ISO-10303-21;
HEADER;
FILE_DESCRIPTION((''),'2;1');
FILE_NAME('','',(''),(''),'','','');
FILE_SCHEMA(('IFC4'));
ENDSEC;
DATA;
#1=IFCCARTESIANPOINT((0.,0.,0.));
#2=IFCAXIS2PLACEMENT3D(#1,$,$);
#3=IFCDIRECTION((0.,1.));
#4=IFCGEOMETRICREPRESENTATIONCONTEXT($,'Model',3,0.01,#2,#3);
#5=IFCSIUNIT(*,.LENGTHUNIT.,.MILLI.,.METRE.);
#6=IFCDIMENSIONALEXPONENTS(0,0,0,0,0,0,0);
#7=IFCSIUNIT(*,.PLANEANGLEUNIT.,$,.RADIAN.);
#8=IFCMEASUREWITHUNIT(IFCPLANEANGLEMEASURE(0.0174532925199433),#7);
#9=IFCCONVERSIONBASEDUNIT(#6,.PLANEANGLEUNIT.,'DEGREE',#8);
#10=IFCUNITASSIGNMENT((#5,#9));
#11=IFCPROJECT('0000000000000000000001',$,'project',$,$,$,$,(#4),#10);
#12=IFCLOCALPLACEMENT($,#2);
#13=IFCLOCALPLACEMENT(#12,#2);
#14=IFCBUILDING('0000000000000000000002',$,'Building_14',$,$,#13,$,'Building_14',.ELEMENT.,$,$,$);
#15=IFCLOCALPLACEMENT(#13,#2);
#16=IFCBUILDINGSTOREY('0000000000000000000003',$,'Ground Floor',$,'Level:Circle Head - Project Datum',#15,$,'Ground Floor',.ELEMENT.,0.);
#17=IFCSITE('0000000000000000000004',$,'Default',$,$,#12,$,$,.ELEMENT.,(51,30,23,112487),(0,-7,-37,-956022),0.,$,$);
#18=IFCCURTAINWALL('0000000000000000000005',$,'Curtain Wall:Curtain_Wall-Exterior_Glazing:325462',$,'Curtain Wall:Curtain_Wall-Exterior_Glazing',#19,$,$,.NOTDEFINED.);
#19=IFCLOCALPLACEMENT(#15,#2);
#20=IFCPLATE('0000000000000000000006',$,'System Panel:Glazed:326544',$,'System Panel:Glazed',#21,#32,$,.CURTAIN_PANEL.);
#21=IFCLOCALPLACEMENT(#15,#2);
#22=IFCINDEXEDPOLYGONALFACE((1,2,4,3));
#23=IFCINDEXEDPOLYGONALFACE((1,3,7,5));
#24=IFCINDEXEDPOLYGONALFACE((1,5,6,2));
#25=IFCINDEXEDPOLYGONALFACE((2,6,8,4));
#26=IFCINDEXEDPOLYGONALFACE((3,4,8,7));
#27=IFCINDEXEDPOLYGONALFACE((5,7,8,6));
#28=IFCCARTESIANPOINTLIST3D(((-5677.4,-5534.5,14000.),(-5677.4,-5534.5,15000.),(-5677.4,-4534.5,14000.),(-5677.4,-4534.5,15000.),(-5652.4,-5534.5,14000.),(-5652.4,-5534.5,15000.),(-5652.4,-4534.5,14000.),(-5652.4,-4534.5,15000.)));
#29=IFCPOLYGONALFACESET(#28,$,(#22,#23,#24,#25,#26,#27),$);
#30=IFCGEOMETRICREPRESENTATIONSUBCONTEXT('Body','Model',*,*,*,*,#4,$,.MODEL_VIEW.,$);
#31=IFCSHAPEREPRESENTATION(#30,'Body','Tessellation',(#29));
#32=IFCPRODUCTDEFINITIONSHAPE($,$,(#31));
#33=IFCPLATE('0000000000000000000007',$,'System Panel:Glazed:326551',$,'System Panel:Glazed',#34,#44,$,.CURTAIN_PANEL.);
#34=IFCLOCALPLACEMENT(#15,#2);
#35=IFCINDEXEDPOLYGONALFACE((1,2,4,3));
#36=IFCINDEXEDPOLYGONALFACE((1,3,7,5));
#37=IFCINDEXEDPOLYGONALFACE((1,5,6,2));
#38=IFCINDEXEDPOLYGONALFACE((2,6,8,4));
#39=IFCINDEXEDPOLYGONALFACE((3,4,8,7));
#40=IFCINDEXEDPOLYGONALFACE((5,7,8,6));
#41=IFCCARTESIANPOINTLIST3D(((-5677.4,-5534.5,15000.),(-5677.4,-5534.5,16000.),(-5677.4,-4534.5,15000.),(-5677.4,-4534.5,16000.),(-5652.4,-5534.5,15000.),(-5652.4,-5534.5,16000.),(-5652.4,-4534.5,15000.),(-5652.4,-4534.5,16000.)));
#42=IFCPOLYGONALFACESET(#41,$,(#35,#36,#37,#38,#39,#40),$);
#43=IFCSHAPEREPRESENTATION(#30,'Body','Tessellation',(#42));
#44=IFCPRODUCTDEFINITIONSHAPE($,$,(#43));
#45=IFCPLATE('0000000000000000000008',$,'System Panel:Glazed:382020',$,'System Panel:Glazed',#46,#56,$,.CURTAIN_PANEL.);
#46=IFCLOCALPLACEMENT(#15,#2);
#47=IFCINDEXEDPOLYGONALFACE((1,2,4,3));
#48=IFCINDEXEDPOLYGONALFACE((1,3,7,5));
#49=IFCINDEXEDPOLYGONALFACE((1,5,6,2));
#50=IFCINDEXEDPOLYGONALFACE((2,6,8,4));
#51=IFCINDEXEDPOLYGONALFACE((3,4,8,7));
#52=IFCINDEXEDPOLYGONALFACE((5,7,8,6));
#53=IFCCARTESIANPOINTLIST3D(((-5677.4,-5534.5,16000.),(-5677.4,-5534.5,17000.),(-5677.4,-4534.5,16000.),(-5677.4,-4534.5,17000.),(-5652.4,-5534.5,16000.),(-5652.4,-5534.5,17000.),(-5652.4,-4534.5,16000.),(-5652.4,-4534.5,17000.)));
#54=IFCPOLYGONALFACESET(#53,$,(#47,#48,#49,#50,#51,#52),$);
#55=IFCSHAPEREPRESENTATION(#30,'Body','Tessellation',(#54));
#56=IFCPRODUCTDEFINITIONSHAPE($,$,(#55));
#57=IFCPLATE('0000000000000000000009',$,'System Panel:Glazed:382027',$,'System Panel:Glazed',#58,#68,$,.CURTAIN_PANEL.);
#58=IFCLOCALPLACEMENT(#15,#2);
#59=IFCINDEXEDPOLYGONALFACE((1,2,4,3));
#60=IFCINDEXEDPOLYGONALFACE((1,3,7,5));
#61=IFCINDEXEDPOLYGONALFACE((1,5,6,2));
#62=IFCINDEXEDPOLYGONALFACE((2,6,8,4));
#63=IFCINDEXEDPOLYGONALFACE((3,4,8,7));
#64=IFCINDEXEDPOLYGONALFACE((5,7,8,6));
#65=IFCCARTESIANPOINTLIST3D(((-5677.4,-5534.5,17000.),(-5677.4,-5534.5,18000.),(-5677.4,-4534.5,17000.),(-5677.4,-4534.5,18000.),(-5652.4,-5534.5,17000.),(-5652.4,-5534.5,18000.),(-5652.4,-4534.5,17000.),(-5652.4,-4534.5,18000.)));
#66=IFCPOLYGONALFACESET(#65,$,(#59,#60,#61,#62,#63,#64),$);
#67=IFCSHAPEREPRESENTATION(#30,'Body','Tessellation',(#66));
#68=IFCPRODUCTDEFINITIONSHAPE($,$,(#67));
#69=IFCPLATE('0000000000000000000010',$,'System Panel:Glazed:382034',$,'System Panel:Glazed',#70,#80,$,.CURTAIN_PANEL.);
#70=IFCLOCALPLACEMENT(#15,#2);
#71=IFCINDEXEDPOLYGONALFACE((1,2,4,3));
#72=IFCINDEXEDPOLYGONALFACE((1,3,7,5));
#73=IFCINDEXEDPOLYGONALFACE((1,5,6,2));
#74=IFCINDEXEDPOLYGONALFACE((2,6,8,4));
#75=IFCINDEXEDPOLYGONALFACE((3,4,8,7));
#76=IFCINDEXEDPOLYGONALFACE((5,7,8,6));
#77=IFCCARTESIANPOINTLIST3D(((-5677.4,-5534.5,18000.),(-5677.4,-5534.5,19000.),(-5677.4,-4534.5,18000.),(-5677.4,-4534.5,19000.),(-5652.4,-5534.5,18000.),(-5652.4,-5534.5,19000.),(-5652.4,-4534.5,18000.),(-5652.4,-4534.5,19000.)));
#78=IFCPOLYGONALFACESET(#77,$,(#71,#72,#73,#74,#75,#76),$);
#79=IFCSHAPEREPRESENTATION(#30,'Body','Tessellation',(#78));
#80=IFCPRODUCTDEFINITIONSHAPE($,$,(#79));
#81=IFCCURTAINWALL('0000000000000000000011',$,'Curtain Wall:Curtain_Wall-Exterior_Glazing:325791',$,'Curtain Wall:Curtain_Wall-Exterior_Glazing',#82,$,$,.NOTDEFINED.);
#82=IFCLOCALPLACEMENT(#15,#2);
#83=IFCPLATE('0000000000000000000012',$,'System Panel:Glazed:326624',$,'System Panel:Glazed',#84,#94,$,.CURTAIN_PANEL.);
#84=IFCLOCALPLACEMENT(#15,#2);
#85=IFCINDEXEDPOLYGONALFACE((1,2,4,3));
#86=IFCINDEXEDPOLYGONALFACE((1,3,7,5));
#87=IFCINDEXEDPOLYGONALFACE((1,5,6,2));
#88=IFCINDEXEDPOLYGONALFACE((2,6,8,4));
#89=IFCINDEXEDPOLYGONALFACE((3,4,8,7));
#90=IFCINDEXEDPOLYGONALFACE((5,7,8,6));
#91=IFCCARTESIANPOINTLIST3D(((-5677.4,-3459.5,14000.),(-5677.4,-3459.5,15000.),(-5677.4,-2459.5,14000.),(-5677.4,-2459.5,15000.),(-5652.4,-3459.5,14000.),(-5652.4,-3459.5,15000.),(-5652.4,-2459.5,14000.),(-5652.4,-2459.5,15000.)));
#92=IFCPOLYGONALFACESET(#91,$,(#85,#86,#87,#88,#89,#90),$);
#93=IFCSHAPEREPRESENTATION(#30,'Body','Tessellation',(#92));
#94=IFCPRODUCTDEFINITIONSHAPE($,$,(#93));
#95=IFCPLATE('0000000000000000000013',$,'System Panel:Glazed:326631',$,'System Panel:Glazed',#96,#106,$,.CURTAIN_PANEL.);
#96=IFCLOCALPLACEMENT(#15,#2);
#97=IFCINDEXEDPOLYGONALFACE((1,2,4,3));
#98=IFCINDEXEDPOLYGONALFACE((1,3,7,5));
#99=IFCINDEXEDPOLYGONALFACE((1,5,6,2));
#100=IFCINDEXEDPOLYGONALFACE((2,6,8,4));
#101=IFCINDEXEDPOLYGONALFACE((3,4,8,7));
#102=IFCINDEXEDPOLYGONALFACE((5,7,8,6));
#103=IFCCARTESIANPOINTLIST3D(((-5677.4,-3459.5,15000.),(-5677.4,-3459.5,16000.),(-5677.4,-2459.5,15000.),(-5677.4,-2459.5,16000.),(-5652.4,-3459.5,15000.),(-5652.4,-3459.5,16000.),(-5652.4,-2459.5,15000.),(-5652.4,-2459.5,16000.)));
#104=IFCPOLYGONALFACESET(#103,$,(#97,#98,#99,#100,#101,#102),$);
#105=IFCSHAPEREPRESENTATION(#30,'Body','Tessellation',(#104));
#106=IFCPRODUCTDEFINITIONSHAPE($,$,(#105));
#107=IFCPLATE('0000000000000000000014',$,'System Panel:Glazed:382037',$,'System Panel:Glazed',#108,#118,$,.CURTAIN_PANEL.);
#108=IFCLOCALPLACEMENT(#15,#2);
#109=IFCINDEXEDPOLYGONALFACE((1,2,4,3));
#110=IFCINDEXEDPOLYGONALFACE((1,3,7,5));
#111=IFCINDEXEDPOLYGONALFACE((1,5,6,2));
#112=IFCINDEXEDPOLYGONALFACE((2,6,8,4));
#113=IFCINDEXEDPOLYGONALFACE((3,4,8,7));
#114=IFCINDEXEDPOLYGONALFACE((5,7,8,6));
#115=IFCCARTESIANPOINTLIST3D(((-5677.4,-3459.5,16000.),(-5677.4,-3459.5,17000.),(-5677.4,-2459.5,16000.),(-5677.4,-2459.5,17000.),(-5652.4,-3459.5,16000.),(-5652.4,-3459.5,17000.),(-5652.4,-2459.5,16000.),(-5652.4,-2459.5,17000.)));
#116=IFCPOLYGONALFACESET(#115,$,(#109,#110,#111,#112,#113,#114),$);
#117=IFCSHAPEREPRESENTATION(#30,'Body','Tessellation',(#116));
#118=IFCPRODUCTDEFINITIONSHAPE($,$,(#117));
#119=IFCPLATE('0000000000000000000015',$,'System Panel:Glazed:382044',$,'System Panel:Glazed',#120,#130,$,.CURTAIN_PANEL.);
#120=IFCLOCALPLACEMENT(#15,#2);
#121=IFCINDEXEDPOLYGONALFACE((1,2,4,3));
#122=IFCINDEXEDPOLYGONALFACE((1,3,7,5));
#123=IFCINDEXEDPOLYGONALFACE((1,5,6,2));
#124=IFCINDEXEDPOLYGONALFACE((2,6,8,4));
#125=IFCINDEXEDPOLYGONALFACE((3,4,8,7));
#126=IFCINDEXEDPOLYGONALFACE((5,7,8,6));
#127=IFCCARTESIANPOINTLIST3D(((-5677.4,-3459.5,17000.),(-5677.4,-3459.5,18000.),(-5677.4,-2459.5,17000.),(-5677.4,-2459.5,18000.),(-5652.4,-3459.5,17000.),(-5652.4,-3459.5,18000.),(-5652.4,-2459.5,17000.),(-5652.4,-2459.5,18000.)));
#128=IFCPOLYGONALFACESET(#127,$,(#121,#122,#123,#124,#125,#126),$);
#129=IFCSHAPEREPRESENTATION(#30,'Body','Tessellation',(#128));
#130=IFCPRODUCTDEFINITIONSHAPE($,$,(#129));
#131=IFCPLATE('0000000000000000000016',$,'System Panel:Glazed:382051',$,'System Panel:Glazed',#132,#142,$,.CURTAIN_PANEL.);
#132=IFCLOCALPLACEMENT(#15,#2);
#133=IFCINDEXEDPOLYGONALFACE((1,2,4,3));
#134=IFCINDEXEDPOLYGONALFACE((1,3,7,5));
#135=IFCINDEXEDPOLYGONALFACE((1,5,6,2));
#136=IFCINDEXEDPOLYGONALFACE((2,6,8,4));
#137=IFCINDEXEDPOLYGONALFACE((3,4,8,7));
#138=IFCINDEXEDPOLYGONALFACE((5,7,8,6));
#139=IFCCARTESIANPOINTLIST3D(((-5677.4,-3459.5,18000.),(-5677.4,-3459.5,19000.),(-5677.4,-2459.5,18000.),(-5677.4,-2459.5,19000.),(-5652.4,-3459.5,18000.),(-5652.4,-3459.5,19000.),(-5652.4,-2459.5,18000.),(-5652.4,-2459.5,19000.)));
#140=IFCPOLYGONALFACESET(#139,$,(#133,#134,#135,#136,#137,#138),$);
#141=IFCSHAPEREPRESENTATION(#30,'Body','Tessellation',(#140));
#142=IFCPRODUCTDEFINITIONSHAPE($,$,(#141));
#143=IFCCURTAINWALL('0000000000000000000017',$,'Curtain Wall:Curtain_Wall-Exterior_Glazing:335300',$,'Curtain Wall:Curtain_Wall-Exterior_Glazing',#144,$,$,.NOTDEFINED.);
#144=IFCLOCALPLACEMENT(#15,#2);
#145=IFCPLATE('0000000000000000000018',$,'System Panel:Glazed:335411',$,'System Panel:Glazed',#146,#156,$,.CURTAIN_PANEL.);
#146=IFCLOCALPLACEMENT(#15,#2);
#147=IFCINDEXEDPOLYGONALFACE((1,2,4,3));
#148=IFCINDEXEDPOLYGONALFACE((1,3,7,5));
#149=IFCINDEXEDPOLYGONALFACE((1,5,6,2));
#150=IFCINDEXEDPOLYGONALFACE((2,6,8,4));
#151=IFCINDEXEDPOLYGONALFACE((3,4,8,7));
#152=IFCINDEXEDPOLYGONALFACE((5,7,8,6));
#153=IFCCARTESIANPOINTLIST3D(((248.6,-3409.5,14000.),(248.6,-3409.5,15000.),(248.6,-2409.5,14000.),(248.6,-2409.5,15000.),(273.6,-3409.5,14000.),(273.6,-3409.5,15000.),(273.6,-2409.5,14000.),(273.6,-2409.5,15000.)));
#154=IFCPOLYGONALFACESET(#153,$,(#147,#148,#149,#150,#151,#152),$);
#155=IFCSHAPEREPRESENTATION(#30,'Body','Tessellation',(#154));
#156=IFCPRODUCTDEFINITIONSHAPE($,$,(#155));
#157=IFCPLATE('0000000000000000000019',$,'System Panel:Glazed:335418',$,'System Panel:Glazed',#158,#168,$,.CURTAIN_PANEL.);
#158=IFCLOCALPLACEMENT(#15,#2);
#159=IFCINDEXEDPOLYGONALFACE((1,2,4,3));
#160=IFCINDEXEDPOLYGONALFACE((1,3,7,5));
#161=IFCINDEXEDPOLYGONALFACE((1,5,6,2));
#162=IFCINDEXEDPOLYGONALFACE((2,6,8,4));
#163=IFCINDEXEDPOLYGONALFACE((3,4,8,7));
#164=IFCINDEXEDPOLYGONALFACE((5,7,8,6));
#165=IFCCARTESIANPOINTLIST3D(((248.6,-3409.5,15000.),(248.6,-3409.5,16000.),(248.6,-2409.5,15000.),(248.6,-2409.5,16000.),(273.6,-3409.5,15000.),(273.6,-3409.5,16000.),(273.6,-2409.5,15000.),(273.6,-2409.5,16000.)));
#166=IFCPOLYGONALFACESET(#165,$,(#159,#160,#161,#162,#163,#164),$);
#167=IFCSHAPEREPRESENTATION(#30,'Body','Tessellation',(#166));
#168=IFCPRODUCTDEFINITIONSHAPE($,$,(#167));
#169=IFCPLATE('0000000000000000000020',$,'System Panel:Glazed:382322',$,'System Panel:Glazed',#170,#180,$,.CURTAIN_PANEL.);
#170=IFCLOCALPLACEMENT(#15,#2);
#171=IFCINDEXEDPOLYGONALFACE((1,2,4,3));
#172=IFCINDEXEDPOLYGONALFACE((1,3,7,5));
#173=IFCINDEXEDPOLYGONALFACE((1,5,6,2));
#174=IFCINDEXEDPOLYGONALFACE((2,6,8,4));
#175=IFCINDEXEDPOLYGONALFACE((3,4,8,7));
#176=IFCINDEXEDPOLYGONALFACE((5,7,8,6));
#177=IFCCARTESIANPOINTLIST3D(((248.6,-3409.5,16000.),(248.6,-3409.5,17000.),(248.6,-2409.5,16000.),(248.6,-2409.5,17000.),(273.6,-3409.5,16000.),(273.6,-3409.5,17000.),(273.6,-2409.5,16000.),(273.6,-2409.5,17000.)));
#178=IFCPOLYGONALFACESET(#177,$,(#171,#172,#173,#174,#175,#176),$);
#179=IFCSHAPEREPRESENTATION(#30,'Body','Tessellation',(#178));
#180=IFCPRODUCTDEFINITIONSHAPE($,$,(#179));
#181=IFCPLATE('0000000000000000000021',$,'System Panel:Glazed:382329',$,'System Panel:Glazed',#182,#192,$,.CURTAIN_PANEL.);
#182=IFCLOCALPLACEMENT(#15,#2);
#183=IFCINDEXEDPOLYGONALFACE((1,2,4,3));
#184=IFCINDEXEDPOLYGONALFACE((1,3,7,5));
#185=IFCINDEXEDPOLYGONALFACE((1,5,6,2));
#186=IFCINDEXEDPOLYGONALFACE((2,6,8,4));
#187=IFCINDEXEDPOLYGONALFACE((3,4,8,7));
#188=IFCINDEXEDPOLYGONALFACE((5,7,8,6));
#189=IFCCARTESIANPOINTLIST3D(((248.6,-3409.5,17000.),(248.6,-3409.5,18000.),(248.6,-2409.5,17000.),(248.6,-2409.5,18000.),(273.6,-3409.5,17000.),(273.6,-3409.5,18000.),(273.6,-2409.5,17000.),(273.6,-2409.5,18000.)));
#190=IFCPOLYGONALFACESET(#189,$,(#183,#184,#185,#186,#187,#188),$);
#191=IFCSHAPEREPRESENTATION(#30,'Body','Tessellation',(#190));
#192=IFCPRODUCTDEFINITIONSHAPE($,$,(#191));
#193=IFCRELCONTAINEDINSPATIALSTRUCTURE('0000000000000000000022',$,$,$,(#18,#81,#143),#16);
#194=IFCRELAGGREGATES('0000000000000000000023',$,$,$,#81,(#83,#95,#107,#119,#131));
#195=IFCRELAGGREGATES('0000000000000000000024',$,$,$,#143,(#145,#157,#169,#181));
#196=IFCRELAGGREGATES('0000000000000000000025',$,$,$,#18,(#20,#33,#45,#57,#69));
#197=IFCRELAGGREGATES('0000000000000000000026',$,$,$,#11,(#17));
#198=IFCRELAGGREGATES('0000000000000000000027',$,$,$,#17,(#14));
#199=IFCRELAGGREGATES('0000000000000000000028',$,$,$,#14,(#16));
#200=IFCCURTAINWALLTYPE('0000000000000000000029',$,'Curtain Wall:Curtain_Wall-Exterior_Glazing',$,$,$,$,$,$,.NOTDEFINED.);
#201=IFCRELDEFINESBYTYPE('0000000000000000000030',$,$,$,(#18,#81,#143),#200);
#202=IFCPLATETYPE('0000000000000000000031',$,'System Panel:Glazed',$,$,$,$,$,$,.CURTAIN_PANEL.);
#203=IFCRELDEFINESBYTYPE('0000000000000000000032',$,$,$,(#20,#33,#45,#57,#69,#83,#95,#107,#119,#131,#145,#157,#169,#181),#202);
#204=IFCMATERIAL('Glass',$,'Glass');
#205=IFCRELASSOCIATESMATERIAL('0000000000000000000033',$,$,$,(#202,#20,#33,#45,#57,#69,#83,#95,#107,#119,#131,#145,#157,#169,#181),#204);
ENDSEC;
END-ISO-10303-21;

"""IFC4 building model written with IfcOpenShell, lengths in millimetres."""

from ifc_helpers import new_model, entity, si_unit, converted_unit, direction, frame, origin, place, context, subcontext, project, spatial, indexed_curve, outline, extrude, source, transform, mapped, material, type_object, type_shapes, element, aggregate, save


model = new_model("IFC4")

# Units and contexts
model_context = context("Model", 3, precision=0.01, world=origin(), true_north=direction((0.0, 1.0)))
body_context = subcontext(model_context, "Body", "Model", "MODEL_VIEW")
ifc_project = project(units=[si_unit("LENGTHUNIT", "METRE", prefix="MILLI"), converted_unit("PLANEANGLEUNIT", "DEGREE", entity("IfcPlaneAngleMeasure", 0.0174532925199433), si_unit("PLANEANGLEUNIT", "RADIAN"), dimensions=[0, 0, 0, 0, 0, 0, 0])], contexts=[model_context])

# Site, building, storey
site_placement = place(None, origin())
site = spatial("IfcSite", under=ifc_project, at=site_placement, Name="Default", CompositionType="ELEMENT", RefLatitude=(51, 30, 23, 112487), RefLongitude=(0, -7, -37, -956022), RefElevation=0.0)
building_placement = place(site_placement, origin())
building = spatial("IfcBuilding", under=site, at=building_placement, Name="Building_14", LongName="Building_14", CompositionType="ELEMENT")
storey_placement = place(building_placement, origin())
storey = spatial("IfcBuildingStorey", under=building, at=storey_placement, Name="Ground Floor", ObjectType="Level:Circle Head - Project Datum", LongName="Ground Floor", CompositionType="ELEMENT", Elevation=0.0)

# Curtain walls, plates
curtain_wall_type = type_object("IfcCurtainWallType", Name="Curtain Wall:Curtain_Wall-Exterior_Glazing", PredefinedType="NOTDEFINED")
curtain_wall_1_placement = place(storey_placement, origin())
curtain_wall_1 = element("IfcCurtainWall", 1, at=curtain_wall_1_placement, inside=storey, type_object=curtain_wall_type, Name="Curtain Wall:Curtain_Wall-Exterior_Glazing:325462", ObjectType="Curtain Wall:Curtain_Wall-Exterior_Glazing", PredefinedType="NOTDEFINED")
ifc_material = material(Name="Glass", Category="Glass")
plate_type_1 = type_object("IfcPlateType", Name="System Panel:Glazed", PredefinedType="CURTAIN_PANEL", material=ifc_material)
shared_shape_1 = source(origin(), body_context, "Body", "SweptSolid", [
    extrude(outline(indexed_curve([(-12.5, -500.0), (12.5, -500.0), (12.5, 500.0), (-12.5, 500.0), (-12.5, -500.0)], self_intersect=False)), frame((0.0, -37.0, 0.0), z_axis=(0.0, 0.0, 1.0), x_axis=(0.0, 1.0, 0.0)), (0.0, 0.0, 1.0), 1000.0),
])
type_shapes(plate_type_1, [shared_shape_1])
plate_1_placement = place(curtain_wall_1_placement, frame((-5701.9, -5034.5, 14000.0), z_axis=(0.0, 0.0, 1.0), x_axis=(0.0, 1.0, 0.0)))
plate_1 = element("IfcPlate", 2, at=plate_1_placement, type_object=plate_type_1, material=ifc_material, Name="System Panel:Glazed:326544", ObjectType="System Panel:Glazed", PredefinedType="CURTAIN_PANEL", context=body_context, shape_type="MappedRepresentation", body=[
    mapped(shared_shape_1, transform((0.0, 0.0, 0.0), scale=1.0)),
])
plate_2_placement = place(curtain_wall_1_placement, frame((-5701.9, -5034.5, 15000.0), z_axis=(0.0, 0.0, 1.0), x_axis=(0.0, 1.0, 0.0)))
plate_2 = element("IfcPlate", 3, at=plate_2_placement, type_object=plate_type_1, material=ifc_material, Name="System Panel:Glazed:326551", ObjectType="System Panel:Glazed", PredefinedType="CURTAIN_PANEL", context=body_context, shape_type="MappedRepresentation", body=[
    mapped(shared_shape_1, transform((0.0, 0.0, 0.0), scale=1.0)),
])
plate_3_placement = place(curtain_wall_1_placement, frame((-5701.9, -5034.5, 16000.0), z_axis=(0.0, 0.0, 1.0), x_axis=(0.0, 1.0, 0.0)))
plate_3 = element("IfcPlate", 4, at=plate_3_placement, type_object=plate_type_1, material=ifc_material, Name="System Panel:Glazed:382020", ObjectType="System Panel:Glazed", PredefinedType="CURTAIN_PANEL", context=body_context, shape_type="MappedRepresentation", body=[
    mapped(shared_shape_1, transform((0.0, 0.0, 0.0), scale=1.0)),
])
plate_4_placement = place(curtain_wall_1_placement, frame((-5701.9, -5034.5, 17000.0), z_axis=(0.0, 0.0, 1.0), x_axis=(0.0, 1.0, 0.0)))
plate_4 = element("IfcPlate", 5, at=plate_4_placement, type_object=plate_type_1, material=ifc_material, Name="System Panel:Glazed:382027", ObjectType="System Panel:Glazed", PredefinedType="CURTAIN_PANEL", context=body_context, shape_type="MappedRepresentation", body=[
    mapped(shared_shape_1, transform((0.0, 0.0, 0.0), scale=1.0)),
])
plate_5_placement = place(curtain_wall_1_placement, frame((-5701.9, -5034.5, 18000.0), z_axis=(0.0, 0.0, 1.0), x_axis=(0.0, 1.0, 0.0)))
plate_5 = element("IfcPlate", 6, at=plate_5_placement, type_object=plate_type_1, material=ifc_material, Name="System Panel:Glazed:382034", ObjectType="System Panel:Glazed", PredefinedType="CURTAIN_PANEL", context=body_context, shape_type="MappedRepresentation", body=[
    mapped(shared_shape_1, transform((0.0, 0.0, 0.0), scale=1.0)),
])
curtain_wall_2_placement = place(storey_placement, origin())
curtain_wall_2 = element("IfcCurtainWall", 7, at=curtain_wall_2_placement, inside=storey, type_object=curtain_wall_type, Name="Curtain Wall:Curtain_Wall-Exterior_Glazing:325791", ObjectType="Curtain Wall:Curtain_Wall-Exterior_Glazing", PredefinedType="NOTDEFINED")
plate_6_placement = place(curtain_wall_2_placement, frame((-5701.9, -2959.5, 14000.0), z_axis=(0.0, 0.0, 1.0), x_axis=(0.0, 1.0, 0.0)))
plate_6 = element("IfcPlate", 8, at=plate_6_placement, type_object=plate_type_1, material=ifc_material, Name="System Panel:Glazed:326624", ObjectType="System Panel:Glazed", PredefinedType="CURTAIN_PANEL", context=body_context, shape_type="MappedRepresentation", body=[
    mapped(shared_shape_1, transform((0.0, 0.0, 0.0), scale=1.0)),
])
plate_7_placement = place(curtain_wall_2_placement, frame((-5701.9, -2959.5, 15000.0), z_axis=(0.0, 0.0, 1.0), x_axis=(0.0, 1.0, 0.0)))
plate_7 = element("IfcPlate", 9, at=plate_7_placement, type_object=plate_type_1, material=ifc_material, Name="System Panel:Glazed:326631", ObjectType="System Panel:Glazed", PredefinedType="CURTAIN_PANEL", context=body_context, shape_type="MappedRepresentation", body=[
    mapped(shared_shape_1, transform((0.0, 0.0, 0.0), scale=1.0)),
])
plate_8_placement = place(curtain_wall_2_placement, frame((-5701.9, -2959.5, 16000.0), z_axis=(0.0, 0.0, 1.0), x_axis=(0.0, 1.0, 0.0)))
plate_8 = element("IfcPlate", 10, at=plate_8_placement, type_object=plate_type_1, material=ifc_material, Name="System Panel:Glazed:382037", ObjectType="System Panel:Glazed", PredefinedType="CURTAIN_PANEL", context=body_context, shape_type="MappedRepresentation", body=[
    mapped(shared_shape_1, transform((0.0, 0.0, 0.0), scale=1.0)),
])
plate_9_placement = place(curtain_wall_2_placement, frame((-5701.9, -2959.5, 17000.0), z_axis=(0.0, 0.0, 1.0), x_axis=(0.0, 1.0, 0.0)))
plate_9 = element("IfcPlate", 11, at=plate_9_placement, type_object=plate_type_1, material=ifc_material, Name="System Panel:Glazed:382044", ObjectType="System Panel:Glazed", PredefinedType="CURTAIN_PANEL", context=body_context, shape_type="MappedRepresentation", body=[
    mapped(shared_shape_1, transform((0.0, 0.0, 0.0), scale=1.0)),
])
plate_10_placement = place(curtain_wall_2_placement, frame((-5701.9, -2959.5, 18000.0), z_axis=(0.0, 0.0, 1.0), x_axis=(0.0, 1.0, 0.0)))
plate_10 = element("IfcPlate", 12, at=plate_10_placement, type_object=plate_type_1, material=ifc_material, Name="System Panel:Glazed:382051", ObjectType="System Panel:Glazed", PredefinedType="CURTAIN_PANEL", context=body_context, shape_type="MappedRepresentation", body=[
    mapped(shared_shape_1, transform((0.0, 0.0, 0.0), scale=1.0)),
])
aggregate(curtain_wall_2, [plate_6, plate_7, plate_8, plate_9, plate_10])
curtain_wall_3_placement = place(storey_placement, origin())
curtain_wall_3 = element("IfcCurtainWall", 13, at=curtain_wall_3_placement, inside=storey, type_object=curtain_wall_type, Name="Curtain Wall:Curtain_Wall-Exterior_Glazing:335300", ObjectType="Curtain Wall:Curtain_Wall-Exterior_Glazing", PredefinedType="NOTDEFINED")
plate_11_placement = place(curtain_wall_3_placement, frame((298.1, -2909.5, 14000.0), z_axis=(0.0, 0.0, 1.0), x_axis=(0.0, -1.0, 0.0)))
plate_11 = element("IfcPlate", 14, at=plate_11_placement, type_object=plate_type_1, material=ifc_material, Name="System Panel:Glazed:335411", ObjectType="System Panel:Glazed", PredefinedType="CURTAIN_PANEL", context=body_context, shape_type="MappedRepresentation", body=[
    mapped(shared_shape_1, transform((0.0, 0.0, 0.0), scale=1.0)),
])
plate_12_placement = place(curtain_wall_3_placement, frame((298.1, -2909.5, 15000.0), z_axis=(0.0, 0.0, 1.0), x_axis=(0.0, -1.0, 0.0)))
plate_12 = element("IfcPlate", 15, at=plate_12_placement, type_object=plate_type_1, material=ifc_material, Name="System Panel:Glazed:335418", ObjectType="System Panel:Glazed", PredefinedType="CURTAIN_PANEL", context=body_context, shape_type="MappedRepresentation", body=[
    mapped(shared_shape_1, transform((0.0, 0.0, 0.0), scale=1.0)),
])
plate_13_placement = place(curtain_wall_3_placement, frame((298.1, -2909.5, 16000.0), z_axis=(0.0, 0.0, 1.0), x_axis=(0.0, -1.0, 0.0)))
plate_13 = element("IfcPlate", 16, at=plate_13_placement, type_object=plate_type_1, material=ifc_material, Name="System Panel:Glazed:382322", ObjectType="System Panel:Glazed", PredefinedType="CURTAIN_PANEL", context=body_context, shape_type="MappedRepresentation", body=[
    mapped(shared_shape_1, transform((0.0, 0.0, 0.0), scale=1.0)),
])
plate_14_placement = place(curtain_wall_3_placement, frame((298.1, -2909.5, 17000.0), z_axis=(0.0, 0.0, 1.0), x_axis=(0.0, -1.0, 0.0)))
plate_14 = element("IfcPlate", 17, at=plate_14_placement, type_object=plate_type_1, material=ifc_material, Name="System Panel:Glazed:382329", ObjectType="System Panel:Glazed", PredefinedType="CURTAIN_PANEL", context=body_context, shape_type="MappedRepresentation", body=[
    mapped(shared_shape_1, transform((0.0, 0.0, 0.0), scale=1.0)),
])

aggregate(curtain_wall_3, [plate_11, plate_12, plate_13, plate_14])
aggregate(curtain_wall_1, [plate_1, plate_2, plate_3, plate_4, plate_5])

save(model, "model.ifc")
